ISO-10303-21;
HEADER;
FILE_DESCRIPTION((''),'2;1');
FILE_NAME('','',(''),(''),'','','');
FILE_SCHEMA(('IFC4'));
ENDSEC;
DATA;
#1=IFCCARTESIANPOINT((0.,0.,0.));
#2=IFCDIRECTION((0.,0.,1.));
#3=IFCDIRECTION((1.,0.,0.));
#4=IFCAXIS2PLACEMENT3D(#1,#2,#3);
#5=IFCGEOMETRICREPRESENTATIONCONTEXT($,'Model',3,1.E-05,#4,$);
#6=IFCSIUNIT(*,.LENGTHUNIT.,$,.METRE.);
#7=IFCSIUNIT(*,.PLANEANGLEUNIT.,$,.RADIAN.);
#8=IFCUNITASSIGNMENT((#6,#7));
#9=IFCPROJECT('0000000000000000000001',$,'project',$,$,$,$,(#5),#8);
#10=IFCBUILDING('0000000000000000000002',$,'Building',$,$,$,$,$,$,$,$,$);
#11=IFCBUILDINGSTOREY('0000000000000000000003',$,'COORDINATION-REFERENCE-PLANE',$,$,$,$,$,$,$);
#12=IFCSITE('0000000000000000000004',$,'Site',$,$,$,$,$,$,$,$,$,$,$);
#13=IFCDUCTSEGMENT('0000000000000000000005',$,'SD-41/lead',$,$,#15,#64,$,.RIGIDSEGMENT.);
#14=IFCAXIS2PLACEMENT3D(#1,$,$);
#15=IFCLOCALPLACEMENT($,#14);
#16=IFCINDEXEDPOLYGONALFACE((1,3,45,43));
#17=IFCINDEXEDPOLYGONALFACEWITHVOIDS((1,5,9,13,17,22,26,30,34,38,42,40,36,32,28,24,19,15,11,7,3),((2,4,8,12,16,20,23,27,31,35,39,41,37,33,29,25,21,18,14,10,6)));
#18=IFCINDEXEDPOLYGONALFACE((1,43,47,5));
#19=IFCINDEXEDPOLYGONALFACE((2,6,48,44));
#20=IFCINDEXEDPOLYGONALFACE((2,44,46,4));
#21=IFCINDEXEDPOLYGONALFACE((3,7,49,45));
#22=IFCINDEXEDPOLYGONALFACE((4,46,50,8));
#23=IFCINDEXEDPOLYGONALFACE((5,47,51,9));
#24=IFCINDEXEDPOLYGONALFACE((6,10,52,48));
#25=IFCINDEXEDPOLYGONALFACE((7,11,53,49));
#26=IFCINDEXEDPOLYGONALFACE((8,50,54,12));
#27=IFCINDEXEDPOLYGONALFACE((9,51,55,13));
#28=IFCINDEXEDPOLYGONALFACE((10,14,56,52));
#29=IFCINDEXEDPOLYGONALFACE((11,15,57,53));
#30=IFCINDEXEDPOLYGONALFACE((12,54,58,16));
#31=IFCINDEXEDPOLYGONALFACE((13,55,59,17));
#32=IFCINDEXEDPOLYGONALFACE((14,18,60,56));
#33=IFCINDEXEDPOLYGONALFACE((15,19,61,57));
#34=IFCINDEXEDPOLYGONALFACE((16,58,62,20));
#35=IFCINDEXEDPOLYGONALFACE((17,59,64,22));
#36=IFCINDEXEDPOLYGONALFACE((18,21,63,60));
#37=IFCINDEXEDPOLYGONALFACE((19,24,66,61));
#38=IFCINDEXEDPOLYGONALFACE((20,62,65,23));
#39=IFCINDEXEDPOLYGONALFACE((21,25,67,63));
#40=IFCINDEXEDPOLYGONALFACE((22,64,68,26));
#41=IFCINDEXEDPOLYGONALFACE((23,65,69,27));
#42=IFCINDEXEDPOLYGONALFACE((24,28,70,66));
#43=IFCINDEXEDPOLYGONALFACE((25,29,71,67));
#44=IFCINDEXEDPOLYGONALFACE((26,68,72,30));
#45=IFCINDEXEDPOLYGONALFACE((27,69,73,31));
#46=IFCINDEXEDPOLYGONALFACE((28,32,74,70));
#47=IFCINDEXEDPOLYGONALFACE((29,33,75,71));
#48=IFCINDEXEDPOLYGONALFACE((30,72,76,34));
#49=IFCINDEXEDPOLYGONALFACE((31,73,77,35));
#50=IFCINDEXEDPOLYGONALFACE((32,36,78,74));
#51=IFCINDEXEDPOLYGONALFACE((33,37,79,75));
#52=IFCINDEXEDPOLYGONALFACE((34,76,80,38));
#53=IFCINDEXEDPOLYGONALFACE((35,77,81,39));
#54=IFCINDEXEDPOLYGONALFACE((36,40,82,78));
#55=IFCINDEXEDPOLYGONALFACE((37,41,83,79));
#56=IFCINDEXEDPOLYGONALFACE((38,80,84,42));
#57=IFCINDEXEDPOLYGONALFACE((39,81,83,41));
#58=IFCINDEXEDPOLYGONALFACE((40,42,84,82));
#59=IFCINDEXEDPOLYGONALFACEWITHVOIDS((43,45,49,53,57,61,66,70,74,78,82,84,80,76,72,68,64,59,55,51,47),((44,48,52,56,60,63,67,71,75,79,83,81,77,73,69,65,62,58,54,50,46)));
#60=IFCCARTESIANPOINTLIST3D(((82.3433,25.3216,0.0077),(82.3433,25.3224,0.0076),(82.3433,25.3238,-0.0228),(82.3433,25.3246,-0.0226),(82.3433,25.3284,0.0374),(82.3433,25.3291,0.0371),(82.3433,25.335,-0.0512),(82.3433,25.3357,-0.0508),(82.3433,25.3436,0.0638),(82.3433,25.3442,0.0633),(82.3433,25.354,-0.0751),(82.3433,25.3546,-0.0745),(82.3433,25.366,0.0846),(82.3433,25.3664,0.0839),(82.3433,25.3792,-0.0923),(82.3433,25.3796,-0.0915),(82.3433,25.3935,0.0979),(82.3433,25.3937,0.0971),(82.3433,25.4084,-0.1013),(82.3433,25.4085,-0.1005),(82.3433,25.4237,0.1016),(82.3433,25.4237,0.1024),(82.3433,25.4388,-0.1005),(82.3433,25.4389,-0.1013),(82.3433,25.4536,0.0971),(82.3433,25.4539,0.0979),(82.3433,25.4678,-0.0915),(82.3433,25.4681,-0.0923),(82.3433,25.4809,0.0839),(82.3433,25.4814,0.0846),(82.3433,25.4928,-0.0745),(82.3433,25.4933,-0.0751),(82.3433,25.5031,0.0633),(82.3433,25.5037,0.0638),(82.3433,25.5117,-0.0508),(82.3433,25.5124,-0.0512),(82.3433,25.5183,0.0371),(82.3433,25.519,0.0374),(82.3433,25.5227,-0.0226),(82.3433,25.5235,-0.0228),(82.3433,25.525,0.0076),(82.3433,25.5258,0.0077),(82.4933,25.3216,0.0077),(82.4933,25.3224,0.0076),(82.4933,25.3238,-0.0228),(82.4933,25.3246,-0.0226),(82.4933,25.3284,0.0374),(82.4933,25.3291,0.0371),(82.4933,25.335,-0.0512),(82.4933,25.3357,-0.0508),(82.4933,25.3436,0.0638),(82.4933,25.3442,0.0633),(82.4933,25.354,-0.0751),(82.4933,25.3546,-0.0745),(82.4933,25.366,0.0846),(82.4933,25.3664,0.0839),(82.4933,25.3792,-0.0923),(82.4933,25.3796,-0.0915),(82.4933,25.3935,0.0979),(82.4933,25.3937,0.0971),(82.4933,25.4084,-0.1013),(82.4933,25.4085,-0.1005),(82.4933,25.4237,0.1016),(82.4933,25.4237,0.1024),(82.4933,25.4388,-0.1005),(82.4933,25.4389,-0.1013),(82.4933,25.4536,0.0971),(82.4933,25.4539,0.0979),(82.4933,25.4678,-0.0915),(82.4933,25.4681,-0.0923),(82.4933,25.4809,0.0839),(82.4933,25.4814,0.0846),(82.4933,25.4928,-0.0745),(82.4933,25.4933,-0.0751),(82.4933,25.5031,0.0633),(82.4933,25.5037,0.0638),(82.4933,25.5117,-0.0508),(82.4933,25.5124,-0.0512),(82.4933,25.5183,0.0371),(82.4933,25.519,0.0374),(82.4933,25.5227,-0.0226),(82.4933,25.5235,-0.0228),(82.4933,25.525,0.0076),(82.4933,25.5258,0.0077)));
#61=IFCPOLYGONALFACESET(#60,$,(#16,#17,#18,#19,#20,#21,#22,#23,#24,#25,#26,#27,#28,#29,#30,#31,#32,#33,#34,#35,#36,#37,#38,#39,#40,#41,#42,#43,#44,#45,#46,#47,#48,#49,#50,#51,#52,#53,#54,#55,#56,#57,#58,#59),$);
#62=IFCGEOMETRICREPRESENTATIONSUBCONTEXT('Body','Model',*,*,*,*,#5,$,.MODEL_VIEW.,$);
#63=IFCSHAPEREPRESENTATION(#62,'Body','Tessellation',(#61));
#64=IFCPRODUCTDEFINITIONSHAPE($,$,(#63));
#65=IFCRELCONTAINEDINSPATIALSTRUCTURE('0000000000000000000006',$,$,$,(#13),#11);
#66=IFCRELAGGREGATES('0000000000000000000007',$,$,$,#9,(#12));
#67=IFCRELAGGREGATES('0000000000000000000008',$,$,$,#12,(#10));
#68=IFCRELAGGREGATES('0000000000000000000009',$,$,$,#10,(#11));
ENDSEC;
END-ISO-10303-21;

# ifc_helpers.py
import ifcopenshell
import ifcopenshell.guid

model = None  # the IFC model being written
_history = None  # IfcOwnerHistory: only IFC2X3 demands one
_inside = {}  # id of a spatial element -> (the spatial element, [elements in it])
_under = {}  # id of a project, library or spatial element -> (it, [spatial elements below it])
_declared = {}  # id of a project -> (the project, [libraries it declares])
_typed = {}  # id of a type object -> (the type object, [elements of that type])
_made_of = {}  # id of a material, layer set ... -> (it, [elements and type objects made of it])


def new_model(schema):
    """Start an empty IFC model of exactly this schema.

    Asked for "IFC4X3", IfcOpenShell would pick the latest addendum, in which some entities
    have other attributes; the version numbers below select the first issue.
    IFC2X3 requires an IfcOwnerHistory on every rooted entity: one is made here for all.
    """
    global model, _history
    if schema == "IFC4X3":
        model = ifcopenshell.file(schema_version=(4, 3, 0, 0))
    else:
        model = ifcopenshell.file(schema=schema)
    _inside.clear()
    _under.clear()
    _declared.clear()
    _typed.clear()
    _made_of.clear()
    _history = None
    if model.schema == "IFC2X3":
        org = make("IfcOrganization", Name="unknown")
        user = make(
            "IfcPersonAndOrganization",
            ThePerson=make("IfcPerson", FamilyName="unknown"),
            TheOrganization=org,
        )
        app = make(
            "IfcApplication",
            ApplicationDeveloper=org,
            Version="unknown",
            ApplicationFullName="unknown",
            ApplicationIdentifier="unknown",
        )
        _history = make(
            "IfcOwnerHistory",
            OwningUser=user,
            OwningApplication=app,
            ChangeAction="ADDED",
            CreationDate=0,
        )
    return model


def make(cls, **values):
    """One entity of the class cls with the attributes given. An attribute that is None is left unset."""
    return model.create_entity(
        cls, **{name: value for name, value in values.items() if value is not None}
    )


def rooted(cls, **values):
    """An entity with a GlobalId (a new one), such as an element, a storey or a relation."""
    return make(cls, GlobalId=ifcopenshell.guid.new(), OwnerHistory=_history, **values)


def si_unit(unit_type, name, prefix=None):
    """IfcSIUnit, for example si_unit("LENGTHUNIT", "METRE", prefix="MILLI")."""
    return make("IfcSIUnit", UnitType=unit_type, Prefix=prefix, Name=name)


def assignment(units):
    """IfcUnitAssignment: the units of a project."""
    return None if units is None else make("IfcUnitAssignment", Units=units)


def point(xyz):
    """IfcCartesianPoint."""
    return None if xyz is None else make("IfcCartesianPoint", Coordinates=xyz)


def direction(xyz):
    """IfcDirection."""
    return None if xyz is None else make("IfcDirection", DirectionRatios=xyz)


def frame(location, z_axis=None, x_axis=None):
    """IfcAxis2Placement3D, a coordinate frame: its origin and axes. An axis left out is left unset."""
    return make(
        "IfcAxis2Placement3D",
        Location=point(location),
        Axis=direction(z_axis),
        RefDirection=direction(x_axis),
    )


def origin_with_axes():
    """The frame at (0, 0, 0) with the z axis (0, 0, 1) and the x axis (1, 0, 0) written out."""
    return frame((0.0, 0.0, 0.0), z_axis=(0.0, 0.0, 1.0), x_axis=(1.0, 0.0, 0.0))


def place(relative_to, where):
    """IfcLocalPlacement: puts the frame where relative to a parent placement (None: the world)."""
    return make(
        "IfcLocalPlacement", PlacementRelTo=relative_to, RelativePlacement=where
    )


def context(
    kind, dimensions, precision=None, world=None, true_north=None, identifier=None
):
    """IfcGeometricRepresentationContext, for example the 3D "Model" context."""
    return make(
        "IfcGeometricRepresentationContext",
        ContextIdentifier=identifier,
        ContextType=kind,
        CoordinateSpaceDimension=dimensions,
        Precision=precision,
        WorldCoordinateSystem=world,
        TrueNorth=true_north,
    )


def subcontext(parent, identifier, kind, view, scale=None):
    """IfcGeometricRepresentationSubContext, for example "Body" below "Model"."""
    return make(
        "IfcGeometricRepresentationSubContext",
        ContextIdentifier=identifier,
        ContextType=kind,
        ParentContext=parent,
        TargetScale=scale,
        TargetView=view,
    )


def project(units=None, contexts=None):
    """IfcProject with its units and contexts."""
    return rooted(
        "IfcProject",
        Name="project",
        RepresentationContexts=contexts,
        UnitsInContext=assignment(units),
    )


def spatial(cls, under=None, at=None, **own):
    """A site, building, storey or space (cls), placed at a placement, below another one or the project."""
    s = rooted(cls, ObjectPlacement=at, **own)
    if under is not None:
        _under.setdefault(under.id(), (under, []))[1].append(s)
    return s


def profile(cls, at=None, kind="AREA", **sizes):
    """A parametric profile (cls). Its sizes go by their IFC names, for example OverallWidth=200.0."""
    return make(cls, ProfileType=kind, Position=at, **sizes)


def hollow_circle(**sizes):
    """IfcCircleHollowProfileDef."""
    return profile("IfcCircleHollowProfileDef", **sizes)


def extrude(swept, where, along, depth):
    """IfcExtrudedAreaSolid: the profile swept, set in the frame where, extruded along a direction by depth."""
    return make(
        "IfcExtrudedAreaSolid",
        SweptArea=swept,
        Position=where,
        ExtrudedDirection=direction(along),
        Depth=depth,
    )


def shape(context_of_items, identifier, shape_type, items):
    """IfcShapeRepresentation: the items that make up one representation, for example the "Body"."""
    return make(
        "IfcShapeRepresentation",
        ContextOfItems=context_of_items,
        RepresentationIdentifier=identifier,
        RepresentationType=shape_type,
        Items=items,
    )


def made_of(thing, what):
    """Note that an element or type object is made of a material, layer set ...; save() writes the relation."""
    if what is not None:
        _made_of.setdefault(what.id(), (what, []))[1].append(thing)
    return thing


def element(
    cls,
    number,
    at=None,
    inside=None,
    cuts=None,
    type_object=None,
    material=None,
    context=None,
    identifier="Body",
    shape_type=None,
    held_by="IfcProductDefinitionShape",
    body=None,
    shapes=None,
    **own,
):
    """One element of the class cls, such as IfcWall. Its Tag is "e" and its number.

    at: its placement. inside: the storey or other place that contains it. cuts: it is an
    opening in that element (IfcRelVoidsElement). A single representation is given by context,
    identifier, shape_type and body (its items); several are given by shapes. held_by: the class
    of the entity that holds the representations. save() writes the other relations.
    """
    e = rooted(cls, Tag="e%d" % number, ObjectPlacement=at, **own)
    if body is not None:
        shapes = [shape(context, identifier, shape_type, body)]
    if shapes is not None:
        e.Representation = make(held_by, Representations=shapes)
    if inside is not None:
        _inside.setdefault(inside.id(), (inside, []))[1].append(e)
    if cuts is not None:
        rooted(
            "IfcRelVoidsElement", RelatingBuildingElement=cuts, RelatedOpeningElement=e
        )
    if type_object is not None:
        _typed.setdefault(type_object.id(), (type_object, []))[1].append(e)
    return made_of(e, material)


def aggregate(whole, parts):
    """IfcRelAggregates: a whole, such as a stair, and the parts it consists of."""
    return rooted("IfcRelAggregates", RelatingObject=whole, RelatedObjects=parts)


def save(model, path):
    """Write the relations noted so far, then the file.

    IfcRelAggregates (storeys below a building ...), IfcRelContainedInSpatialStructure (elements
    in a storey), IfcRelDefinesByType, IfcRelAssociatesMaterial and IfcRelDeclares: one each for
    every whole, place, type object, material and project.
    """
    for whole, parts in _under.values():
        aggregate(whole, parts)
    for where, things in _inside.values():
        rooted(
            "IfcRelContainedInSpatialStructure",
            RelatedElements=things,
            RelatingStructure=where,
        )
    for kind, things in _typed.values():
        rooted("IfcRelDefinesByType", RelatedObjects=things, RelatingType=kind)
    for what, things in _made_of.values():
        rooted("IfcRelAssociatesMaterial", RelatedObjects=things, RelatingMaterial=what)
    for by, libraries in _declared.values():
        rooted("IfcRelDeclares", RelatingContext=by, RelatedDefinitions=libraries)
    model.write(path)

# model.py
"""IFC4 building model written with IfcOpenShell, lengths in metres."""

from ifc_helpers import new_model, si_unit, frame, origin_with_axes, place, context, subcontext, project, spatial, hollow_circle, extrude, element, save


model = new_model("IFC4")

# Units and contexts
model_context = context("Model", 3, precision=1e-05, world=origin_with_axes())
body_context_1 = subcontext(model_context, "Body", "Model", "MODEL_VIEW")
ifc_project = project(units=[si_unit("LENGTHUNIT", "METRE"), si_unit("PLANEANGLEUNIT", "RADIAN")], contexts=[model_context])

# Site, building, storey
site = spatial("IfcSite", under=ifc_project, Name="Site")
building = spatial("IfcBuilding", under=site, Name="Building")
storey = spatial("IfcBuildingStorey", under=building, Name="COORDINATION-REFERENCE-PLANE")

# Duct segment
duct_segment_1_placement = place(None, frame((82.4933, 25.4237, 0.0), z_axis=(-1.0, 0.0, 0.0), x_axis=(0.0, 0.0, 1.0)))
element("IfcDuctSegment", 1, at=duct_segment_1_placement, inside=storey, Name="SD-41/lead", PredefinedType="RIGIDSEGMENT", context=body_context_1, shape_type="SweptSolid", body=[
    extrude(hollow_circle(Radius=0.1024, WallThickness=0.0008), origin_with_axes(), (0.0, 0.0, 1.0), 0.15),
])

save(model, "model.ifc")
